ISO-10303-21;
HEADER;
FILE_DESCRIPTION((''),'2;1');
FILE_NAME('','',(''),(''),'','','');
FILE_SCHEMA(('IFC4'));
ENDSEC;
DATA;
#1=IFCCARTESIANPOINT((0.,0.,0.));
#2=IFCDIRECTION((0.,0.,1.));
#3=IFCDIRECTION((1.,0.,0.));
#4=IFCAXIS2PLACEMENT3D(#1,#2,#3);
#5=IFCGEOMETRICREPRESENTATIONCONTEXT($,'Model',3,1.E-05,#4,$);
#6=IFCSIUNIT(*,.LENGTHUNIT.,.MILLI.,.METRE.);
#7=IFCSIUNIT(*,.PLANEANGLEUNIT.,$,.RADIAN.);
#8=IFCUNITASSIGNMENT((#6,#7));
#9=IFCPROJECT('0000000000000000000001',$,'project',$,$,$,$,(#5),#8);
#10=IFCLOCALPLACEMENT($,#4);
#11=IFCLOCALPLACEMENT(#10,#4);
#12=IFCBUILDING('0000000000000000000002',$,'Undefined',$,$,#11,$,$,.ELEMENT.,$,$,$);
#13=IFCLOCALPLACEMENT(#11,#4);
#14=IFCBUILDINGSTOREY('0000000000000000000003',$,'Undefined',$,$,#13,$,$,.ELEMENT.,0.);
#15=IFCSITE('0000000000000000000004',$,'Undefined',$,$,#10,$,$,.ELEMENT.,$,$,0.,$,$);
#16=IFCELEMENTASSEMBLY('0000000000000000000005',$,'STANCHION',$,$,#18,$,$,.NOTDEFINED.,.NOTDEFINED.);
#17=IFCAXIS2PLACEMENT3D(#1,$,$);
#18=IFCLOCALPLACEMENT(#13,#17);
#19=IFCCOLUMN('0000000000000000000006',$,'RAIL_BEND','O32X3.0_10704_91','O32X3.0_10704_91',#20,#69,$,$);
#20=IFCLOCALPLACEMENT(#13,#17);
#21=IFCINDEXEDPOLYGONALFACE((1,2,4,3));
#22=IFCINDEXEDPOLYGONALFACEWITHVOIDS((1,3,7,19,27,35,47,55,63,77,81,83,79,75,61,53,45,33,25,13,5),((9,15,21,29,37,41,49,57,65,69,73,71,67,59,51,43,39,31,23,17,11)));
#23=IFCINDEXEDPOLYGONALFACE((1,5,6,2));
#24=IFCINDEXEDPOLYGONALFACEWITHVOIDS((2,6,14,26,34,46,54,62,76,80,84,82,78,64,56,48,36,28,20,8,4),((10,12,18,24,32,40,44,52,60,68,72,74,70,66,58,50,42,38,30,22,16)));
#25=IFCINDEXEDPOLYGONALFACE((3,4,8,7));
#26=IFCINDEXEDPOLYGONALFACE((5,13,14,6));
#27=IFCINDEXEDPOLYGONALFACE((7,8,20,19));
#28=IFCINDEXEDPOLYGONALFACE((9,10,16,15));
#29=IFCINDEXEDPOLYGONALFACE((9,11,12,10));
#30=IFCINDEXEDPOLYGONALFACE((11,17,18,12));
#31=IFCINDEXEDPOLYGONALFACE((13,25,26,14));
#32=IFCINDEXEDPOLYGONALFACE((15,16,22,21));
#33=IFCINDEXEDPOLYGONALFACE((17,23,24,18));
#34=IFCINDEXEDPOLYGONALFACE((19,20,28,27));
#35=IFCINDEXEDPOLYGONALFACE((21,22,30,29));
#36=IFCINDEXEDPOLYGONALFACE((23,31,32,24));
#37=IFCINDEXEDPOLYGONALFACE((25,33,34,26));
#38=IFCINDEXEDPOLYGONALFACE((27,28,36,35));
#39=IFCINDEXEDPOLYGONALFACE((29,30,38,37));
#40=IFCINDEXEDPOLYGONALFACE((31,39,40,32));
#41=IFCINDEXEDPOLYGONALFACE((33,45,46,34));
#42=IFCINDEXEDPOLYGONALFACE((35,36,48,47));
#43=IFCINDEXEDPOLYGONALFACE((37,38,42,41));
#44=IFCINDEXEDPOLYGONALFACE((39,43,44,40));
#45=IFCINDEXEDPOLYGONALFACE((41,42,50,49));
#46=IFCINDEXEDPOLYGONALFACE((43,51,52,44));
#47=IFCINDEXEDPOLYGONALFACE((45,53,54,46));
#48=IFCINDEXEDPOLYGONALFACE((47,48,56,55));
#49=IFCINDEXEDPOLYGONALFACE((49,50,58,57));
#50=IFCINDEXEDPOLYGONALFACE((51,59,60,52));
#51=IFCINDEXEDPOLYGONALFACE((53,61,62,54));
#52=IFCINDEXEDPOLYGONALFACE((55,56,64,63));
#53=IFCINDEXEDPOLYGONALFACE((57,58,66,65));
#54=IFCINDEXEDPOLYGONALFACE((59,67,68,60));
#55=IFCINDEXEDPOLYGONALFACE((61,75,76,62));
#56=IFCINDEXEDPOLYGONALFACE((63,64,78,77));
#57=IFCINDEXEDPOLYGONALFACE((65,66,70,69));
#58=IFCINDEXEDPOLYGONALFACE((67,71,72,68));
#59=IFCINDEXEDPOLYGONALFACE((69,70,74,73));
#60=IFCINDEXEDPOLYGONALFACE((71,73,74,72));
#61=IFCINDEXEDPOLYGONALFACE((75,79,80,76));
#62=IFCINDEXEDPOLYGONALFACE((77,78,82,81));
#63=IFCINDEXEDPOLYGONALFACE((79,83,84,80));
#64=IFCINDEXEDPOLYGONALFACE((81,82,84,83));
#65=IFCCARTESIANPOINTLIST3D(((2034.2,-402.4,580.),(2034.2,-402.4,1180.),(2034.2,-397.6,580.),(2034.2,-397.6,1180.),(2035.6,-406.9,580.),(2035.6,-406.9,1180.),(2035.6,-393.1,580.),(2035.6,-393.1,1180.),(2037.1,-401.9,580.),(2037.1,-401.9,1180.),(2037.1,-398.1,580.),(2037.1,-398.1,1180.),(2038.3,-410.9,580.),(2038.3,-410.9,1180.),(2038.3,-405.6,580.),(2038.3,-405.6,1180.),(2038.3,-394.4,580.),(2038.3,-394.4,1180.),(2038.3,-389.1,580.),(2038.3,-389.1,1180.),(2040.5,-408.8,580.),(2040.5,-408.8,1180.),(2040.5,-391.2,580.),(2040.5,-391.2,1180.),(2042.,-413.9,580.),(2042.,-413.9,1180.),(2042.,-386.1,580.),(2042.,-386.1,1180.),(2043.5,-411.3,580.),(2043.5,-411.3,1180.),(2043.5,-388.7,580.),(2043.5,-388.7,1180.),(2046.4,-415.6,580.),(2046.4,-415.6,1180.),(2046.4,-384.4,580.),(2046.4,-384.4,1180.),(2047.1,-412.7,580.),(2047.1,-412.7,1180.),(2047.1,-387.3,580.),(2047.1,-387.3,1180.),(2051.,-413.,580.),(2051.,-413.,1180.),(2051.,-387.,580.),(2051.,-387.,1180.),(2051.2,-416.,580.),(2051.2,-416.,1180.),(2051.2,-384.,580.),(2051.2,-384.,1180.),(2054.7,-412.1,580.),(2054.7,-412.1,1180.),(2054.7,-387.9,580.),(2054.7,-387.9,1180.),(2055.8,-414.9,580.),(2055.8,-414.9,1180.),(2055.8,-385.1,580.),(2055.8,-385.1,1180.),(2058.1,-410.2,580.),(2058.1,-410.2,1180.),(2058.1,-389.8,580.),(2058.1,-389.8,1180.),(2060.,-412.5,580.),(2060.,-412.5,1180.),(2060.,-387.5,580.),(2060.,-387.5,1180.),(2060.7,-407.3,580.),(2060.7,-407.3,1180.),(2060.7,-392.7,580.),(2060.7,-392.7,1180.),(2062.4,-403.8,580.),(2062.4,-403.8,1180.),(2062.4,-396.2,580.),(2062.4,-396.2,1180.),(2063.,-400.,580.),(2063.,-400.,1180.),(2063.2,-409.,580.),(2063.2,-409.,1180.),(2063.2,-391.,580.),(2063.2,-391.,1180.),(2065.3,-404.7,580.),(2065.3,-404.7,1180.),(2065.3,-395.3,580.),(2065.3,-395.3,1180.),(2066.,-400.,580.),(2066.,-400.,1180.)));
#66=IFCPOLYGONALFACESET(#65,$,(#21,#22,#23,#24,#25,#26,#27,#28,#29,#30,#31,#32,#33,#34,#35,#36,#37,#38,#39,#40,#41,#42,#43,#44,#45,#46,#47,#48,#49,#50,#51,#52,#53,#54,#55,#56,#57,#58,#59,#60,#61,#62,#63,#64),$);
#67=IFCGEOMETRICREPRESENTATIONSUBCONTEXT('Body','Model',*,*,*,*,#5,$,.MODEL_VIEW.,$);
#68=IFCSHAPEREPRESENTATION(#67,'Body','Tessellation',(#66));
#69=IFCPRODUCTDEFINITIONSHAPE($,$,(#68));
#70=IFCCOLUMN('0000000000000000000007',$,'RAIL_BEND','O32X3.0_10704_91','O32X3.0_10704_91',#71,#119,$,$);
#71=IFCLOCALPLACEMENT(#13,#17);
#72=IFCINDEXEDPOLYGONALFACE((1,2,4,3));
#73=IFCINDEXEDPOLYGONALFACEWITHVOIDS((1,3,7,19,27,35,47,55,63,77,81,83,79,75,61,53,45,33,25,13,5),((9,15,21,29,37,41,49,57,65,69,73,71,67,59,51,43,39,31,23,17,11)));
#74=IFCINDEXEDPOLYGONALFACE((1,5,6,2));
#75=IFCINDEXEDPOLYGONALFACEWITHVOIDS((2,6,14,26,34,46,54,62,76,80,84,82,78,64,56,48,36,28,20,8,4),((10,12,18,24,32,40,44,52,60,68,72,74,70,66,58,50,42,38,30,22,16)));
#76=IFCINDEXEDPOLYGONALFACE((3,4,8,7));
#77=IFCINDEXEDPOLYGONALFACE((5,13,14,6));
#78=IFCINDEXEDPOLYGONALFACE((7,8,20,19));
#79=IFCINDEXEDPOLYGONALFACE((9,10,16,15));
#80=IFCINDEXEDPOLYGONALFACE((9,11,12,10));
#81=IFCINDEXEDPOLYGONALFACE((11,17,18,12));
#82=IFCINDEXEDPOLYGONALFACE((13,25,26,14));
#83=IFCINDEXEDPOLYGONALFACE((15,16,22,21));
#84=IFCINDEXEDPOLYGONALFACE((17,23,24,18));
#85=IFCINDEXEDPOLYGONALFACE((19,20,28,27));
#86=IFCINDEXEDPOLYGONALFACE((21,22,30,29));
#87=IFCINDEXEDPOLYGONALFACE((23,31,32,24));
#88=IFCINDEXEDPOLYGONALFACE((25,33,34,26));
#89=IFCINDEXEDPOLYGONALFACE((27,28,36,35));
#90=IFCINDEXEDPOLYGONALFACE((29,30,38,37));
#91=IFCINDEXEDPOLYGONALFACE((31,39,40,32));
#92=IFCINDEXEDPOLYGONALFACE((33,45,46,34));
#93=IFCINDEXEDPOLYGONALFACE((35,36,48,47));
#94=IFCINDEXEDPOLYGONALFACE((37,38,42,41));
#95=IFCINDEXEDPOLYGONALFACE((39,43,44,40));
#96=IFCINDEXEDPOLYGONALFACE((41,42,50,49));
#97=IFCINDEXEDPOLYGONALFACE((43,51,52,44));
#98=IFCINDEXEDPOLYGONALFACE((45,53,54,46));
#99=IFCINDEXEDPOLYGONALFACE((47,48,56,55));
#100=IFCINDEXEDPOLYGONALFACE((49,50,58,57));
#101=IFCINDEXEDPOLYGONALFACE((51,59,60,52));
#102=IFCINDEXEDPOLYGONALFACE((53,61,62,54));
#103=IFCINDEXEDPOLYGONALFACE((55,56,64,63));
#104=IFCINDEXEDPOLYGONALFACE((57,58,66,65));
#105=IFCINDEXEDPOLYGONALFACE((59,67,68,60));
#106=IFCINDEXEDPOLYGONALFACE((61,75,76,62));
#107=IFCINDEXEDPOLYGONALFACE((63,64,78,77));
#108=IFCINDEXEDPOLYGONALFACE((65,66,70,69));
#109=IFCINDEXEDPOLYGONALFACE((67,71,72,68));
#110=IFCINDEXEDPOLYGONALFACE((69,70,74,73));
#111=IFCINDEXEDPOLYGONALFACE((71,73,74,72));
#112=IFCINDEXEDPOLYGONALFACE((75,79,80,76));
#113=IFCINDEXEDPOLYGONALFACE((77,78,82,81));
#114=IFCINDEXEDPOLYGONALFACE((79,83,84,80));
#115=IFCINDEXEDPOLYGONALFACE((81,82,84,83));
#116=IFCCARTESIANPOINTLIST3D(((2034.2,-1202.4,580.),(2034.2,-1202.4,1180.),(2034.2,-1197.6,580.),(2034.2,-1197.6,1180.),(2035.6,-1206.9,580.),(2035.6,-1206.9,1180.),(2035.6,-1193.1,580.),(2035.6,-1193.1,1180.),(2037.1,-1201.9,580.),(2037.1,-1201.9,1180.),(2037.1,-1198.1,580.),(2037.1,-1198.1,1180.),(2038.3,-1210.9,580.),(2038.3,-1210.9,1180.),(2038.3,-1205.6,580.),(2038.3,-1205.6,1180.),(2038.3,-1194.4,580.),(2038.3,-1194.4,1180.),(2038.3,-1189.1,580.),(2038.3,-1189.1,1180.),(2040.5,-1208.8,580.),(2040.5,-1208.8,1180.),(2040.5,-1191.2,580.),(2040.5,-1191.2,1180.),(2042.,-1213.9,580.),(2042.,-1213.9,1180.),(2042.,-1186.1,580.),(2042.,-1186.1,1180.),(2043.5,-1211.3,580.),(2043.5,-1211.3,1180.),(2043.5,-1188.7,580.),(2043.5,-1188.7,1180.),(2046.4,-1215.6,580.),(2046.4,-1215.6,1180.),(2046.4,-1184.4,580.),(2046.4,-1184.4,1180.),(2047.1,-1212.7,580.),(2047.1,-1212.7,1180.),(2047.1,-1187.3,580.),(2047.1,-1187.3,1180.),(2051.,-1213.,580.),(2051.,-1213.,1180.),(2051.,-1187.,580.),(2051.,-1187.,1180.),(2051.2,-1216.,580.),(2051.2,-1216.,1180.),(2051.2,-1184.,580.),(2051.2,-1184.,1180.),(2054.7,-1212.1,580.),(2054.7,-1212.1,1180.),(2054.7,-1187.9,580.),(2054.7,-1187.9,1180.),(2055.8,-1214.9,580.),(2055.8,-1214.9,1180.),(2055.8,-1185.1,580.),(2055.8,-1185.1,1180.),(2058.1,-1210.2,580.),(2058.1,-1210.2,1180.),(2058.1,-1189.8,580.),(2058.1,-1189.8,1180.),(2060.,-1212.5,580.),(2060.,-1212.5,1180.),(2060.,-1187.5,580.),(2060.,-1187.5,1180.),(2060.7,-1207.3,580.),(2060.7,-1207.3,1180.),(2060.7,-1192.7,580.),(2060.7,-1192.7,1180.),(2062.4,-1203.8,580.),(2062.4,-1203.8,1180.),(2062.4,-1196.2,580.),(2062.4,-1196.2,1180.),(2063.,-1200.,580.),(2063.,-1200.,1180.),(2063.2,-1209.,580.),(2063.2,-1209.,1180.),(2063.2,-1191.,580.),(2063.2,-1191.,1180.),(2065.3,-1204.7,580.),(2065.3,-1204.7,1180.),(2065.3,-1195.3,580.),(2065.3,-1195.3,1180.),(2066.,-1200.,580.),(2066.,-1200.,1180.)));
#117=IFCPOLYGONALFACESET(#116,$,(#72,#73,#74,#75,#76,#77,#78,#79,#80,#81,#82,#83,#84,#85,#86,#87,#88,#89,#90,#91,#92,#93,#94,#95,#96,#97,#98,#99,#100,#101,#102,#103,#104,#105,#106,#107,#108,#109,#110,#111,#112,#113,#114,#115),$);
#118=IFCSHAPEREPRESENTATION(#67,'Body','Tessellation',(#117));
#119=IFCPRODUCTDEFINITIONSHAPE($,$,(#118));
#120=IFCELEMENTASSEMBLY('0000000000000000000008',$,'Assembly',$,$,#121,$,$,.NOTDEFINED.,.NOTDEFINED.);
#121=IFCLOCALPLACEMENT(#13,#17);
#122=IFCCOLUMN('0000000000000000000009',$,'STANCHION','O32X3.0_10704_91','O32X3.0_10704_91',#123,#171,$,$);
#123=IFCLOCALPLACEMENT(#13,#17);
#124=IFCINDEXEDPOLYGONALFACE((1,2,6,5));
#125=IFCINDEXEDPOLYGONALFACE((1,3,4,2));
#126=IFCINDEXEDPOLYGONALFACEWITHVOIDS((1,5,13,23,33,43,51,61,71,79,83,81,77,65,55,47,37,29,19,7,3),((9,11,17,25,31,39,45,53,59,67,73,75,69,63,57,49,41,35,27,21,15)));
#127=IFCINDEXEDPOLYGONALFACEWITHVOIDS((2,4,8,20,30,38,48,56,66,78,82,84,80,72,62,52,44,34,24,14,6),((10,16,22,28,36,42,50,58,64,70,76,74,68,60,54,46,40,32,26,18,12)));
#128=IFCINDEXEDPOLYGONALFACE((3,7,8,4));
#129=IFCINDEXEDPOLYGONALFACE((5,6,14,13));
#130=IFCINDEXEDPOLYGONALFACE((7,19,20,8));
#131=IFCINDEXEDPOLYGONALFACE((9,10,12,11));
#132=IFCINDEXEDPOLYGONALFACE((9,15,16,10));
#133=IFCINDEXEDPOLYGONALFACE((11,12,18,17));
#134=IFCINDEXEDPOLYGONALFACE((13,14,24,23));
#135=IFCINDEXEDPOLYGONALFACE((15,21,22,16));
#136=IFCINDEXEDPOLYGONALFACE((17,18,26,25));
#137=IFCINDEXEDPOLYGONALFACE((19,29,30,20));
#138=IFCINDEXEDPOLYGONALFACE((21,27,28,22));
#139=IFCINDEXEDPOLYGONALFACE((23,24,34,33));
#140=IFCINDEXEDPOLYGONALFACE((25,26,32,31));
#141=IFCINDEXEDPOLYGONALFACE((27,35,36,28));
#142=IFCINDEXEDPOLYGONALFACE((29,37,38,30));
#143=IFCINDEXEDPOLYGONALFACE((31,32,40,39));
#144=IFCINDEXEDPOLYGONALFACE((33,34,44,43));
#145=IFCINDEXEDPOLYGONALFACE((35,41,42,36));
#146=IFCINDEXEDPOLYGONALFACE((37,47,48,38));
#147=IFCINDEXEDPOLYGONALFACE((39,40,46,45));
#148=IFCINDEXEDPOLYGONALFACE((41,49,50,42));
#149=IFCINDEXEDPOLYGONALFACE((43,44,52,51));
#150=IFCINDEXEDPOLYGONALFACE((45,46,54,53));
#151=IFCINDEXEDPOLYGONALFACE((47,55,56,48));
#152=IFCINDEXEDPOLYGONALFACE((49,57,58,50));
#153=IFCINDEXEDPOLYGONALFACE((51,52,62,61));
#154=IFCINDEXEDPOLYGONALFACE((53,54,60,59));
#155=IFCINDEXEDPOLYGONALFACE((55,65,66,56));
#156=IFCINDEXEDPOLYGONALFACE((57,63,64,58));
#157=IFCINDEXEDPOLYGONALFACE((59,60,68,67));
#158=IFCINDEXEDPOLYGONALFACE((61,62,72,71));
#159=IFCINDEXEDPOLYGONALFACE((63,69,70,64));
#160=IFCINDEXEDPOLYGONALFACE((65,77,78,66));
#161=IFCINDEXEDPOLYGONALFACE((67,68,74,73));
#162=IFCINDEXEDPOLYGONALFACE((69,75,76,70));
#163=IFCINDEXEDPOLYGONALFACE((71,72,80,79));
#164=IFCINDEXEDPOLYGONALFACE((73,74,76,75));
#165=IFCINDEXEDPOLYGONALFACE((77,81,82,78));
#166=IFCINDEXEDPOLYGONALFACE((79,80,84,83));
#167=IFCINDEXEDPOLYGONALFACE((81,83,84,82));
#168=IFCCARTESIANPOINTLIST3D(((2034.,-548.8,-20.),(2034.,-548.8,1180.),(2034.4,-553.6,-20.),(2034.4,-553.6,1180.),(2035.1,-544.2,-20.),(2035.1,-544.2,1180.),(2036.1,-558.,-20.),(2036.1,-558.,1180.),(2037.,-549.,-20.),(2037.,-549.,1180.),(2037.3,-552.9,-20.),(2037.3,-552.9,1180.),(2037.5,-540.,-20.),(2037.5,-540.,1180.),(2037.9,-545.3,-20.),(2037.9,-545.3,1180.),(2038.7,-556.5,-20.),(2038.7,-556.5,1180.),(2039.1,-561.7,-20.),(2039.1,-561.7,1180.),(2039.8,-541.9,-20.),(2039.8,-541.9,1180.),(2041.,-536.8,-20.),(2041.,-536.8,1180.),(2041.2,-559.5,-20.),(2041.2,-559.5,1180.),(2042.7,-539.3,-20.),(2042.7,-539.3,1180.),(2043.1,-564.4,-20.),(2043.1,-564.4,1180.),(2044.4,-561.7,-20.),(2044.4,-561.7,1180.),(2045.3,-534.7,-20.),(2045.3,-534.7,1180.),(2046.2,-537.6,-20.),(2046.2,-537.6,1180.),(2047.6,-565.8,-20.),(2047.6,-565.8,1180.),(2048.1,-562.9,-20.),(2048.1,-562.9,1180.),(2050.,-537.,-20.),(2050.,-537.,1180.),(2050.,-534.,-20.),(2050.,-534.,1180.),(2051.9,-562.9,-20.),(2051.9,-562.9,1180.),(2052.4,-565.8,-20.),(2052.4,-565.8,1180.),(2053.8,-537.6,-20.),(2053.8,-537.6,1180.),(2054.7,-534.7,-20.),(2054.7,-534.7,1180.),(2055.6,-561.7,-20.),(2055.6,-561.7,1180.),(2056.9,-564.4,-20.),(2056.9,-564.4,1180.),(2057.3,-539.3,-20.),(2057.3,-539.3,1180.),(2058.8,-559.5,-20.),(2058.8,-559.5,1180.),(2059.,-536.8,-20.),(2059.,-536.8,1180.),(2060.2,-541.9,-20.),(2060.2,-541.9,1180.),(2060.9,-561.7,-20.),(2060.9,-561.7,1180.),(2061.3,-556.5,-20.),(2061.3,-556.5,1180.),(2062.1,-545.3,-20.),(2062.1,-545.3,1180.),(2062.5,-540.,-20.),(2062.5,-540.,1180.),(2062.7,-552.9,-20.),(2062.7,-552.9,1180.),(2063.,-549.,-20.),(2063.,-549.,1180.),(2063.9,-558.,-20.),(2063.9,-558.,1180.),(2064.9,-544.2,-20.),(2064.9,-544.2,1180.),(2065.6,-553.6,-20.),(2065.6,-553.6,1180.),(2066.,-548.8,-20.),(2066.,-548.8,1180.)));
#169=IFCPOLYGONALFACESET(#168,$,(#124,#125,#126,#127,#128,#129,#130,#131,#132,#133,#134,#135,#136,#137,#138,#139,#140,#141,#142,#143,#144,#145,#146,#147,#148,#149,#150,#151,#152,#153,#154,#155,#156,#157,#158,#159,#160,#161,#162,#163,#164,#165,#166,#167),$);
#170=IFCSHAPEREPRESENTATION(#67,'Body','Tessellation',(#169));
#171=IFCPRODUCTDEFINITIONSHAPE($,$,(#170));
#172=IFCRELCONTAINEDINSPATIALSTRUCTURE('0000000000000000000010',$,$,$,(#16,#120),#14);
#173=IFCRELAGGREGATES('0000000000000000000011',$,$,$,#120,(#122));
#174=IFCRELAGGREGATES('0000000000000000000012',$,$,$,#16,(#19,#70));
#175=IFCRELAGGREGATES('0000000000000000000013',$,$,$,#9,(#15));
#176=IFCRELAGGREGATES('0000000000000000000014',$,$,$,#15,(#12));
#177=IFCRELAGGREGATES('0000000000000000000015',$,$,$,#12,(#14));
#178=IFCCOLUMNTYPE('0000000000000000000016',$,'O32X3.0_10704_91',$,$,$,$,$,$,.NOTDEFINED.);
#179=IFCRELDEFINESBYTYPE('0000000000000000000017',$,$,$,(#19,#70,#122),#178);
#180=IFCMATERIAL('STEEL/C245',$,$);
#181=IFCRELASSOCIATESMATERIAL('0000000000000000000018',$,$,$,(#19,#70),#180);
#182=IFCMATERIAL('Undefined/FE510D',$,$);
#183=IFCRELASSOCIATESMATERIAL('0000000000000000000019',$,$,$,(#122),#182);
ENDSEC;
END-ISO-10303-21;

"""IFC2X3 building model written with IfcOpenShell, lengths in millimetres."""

from ifc_helpers import new_model, si_unit, frame, origin_with_axes, origin_2d_with_axis, place, context, subcontext, project, spatial, hollow_circle, extrude, material, type_object, element, aggregate, save


model = new_model("IFC2X3")

# Units and contexts
model_context = context("Model", 3, precision=1e-05, world=origin_with_axes())
body_context = subcontext(model_context, "Body", "Model", "MODEL_VIEW")
ifc_project = project(units=[si_unit("LENGTHUNIT", "METRE", prefix="MILLI"), si_unit("PLANEANGLEUNIT", "RADIAN")], contexts=[model_context])

# Site, building, storey
site_placement = place(None, origin_with_axes())
site = spatial("IfcSite", under=ifc_project, at=site_placement, Name="Undefined", CompositionType="ELEMENT", RefElevation=0.0)
building_placement = place(site_placement, origin_with_axes())
building = spatial("IfcBuilding", under=site, at=building_placement, Name="Undefined", CompositionType="ELEMENT")
storey_placement = place(building_placement, origin_with_axes())
storey = spatial("IfcBuildingStorey", under=building, at=storey_placement, Name="Undefined", CompositionType="ELEMENT", Elevation=0.0)

# Element assembly, columns
assembly_1_placement = place(storey_placement, origin_with_axes())
assembly_1 = element("IfcElementAssembly", 1, at=assembly_1_placement, inside=storey, Name="STANCHION", AssemblyPlace="NOTDEFINED", PredefinedType="NOTDEFINED")
ifc_material_1 = material(Name="STEEL/C245")
column_type = type_object("IfcColumnType", Name="O32X3.0_10704_91", PredefinedType="NOTDEFINED")
column_1_placement = place(assembly_1_placement, frame((2050.0, -400.0, 580.0), z_axis=(0.0, 0.0, 1.0), x_axis=(0.0, -1.0, 0.0)))
column_1 = element("IfcColumn", 2, at=column_1_placement, type_object=column_type, material=ifc_material_1, Name="RAIL_BEND", Description="O32X3.0_10704_91", ObjectType="O32X3.0_10704_91", context=body_context, shape_type="SweptSolid", body=[
    extrude(hollow_circle(Radius=16.0, WallThickness=3.0, at=origin_2d_with_axis()), frame((0.0, 0.0, 600.0), z_axis=(0.0, 0.0, -1.0), x_axis=(0.0, 1.0, 0.0)), (0.0, 0.0, 1.0), 600.0),
])
column_2_placement = place(assembly_1_placement, frame((2050.0, -1200.0, 580.0), z_axis=(0.0, 0.0, 1.0), x_axis=(0.0, -1.0, 0.0)))
column_2 = element("IfcColumn", 3, at=column_2_placement, type_object=column_type, material=ifc_material_1, Name="RAIL_BEND", Description="O32X3.0_10704_91", ObjectType="O32X3.0_10704_91", context=body_context, shape_type="SweptSolid", body=[
    extrude(hollow_circle(Radius=16.0, WallThickness=3.0, at=origin_2d_with_axis()), frame((0.0, 0.0, 600.0), z_axis=(0.0, 0.0, -1.0), x_axis=(0.0, 1.0, 0.0)), (0.0, 0.0, 1.0), 600.0),
])

# Element assembly, column
assembly_2_placement = place(storey_placement, origin_with_axes())
assembly_2 = element("IfcElementAssembly", 4, at=assembly_2_placement, inside=storey, Name="Assembly", AssemblyPlace="NOTDEFINED", PredefinedType="NOTDEFINED")
ifc_material_2 = material(Name="Undefined/FE510D")
column_3_placement = place(assembly_2_placement, frame((2050.0, -550.0, -20.0), z_axis=(0.0, 0.0, 1.0), x_axis=(1.0, 0.0, 0.0)))
column_3 = element("IfcColumn", 5, at=column_3_placement, type_object=column_type, material=ifc_material_2, Name="STANCHION", Description="O32X3.0_10704_91", ObjectType="O32X3.0_10704_91", context=body_context, shape_type="SweptSolid", body=[
    extrude(hollow_circle(Radius=16.0, WallThickness=3.0, at=origin_2d_with_axis()), frame((0.0, 0.0, 1200.0), z_axis=(0.0, 0.0, -1.0), x_axis=(0.0, 1.0, 0.0)), (0.0, 0.0, 1.0), 1200.0),
])
aggregate(assembly_2, [column_3])

aggregate(assembly_1, [column_1, column_2])

save(model, "model.ifc")
